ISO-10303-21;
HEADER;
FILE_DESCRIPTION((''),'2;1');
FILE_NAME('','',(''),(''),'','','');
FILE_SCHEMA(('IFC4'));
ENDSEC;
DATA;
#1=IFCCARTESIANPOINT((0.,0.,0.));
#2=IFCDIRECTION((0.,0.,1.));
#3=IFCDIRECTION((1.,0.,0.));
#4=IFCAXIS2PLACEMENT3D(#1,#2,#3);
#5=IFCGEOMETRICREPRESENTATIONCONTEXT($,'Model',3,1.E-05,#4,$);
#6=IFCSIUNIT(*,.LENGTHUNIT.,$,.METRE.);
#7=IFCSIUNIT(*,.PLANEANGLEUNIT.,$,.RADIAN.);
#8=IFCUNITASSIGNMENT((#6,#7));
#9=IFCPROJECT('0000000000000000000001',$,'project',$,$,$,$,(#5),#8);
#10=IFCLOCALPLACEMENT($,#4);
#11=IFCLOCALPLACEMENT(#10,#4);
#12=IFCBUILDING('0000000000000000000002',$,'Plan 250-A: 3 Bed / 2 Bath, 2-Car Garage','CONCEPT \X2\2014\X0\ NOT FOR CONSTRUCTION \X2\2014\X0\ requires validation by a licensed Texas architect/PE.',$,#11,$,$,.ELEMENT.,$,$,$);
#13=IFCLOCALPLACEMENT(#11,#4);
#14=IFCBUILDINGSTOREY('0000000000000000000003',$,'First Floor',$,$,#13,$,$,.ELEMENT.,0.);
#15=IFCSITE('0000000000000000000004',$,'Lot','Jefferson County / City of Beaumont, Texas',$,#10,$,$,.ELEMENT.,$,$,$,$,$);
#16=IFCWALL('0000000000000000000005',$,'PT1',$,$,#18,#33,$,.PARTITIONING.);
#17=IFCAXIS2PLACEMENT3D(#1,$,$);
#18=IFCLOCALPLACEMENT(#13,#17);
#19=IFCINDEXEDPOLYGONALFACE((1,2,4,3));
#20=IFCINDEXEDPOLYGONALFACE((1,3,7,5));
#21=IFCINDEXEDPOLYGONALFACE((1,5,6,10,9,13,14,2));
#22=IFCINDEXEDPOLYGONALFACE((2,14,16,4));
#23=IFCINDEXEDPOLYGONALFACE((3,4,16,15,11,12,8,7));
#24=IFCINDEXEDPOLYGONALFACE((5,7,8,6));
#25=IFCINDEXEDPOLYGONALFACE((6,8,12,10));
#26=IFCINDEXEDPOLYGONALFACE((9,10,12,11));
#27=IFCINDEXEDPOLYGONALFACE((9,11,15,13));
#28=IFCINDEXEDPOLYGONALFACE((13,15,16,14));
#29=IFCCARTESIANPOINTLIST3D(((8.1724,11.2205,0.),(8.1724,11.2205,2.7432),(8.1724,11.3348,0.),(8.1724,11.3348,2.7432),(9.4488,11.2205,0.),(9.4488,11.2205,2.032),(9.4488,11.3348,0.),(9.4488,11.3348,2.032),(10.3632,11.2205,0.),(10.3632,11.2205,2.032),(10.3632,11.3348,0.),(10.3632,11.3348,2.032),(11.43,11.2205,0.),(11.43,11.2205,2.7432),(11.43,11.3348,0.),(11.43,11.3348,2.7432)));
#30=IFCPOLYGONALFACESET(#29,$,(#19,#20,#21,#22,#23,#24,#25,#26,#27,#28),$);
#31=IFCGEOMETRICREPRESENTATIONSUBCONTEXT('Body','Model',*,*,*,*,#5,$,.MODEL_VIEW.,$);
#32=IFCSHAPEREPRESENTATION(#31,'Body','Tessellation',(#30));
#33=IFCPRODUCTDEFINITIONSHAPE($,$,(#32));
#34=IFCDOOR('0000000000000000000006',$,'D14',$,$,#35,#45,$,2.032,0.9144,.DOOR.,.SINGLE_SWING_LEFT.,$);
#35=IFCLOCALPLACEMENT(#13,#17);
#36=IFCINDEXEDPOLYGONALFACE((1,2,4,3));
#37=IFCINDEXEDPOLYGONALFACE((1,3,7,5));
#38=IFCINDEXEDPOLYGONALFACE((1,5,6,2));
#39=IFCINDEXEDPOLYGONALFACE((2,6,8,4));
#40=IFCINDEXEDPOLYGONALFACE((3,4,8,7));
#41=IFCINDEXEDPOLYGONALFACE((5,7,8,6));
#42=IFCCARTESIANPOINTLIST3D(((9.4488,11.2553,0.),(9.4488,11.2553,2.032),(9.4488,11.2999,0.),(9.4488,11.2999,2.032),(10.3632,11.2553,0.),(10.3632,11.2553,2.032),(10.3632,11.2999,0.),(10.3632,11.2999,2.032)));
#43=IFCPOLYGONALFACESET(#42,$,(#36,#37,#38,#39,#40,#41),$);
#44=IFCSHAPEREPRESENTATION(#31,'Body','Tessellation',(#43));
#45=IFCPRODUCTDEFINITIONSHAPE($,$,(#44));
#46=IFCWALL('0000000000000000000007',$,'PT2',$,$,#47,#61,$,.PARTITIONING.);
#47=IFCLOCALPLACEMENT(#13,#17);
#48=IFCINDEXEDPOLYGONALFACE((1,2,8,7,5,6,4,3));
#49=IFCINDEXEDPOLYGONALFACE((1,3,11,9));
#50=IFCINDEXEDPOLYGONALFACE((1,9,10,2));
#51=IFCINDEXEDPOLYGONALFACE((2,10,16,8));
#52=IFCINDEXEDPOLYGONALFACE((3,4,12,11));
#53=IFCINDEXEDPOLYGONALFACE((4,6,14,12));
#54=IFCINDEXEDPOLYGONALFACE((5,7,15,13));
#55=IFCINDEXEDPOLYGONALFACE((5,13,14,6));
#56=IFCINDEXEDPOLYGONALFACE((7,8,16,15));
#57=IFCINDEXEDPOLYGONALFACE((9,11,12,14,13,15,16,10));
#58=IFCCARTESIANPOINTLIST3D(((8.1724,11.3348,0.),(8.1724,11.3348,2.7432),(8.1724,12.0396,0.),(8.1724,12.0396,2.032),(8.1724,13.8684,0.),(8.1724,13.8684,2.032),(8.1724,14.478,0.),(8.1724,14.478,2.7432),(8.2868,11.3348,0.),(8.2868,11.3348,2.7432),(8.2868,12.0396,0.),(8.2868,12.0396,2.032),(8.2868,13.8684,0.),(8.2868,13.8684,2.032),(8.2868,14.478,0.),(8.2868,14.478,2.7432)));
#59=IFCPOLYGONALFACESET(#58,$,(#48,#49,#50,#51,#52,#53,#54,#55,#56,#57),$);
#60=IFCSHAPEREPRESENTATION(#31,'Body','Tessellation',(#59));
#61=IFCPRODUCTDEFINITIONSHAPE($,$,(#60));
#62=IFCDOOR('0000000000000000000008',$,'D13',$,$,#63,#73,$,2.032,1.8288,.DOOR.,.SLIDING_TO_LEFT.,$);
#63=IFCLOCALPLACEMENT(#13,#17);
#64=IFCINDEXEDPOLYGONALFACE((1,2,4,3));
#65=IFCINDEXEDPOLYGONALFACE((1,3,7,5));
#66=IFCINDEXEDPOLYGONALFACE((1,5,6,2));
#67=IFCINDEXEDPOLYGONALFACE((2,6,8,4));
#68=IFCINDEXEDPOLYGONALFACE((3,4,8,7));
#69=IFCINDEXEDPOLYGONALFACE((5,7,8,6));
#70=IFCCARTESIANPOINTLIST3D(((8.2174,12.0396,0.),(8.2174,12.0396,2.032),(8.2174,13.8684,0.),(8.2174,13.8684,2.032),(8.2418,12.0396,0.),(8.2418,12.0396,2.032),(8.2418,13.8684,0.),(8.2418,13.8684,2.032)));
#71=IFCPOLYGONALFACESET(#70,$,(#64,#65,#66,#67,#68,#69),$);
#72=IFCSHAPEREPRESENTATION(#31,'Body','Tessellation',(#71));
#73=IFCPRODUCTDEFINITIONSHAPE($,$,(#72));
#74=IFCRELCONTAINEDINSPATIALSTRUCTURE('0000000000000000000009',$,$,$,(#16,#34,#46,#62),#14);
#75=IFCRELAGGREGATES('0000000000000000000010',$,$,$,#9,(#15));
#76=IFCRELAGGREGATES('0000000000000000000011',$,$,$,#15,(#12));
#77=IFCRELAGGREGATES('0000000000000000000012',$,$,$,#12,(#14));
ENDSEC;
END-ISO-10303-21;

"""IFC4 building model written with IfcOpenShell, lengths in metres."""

from ifc_helpers import new_model, si_unit, frame, frame_2d, origin_with_axes, place, context, subcontext, project, spatial, rectangle, extrude, element, fill, save


model = new_model("IFC4")

# Units and contexts
model_context = context("Model", 3, precision=1e-05, world=origin_with_axes())
body_context = subcontext(model_context, "Body", "Model", "MODEL_VIEW")
ifc_project = project(units=[si_unit("LENGTHUNIT", "METRE"), si_unit("PLANEANGLEUNIT", "RADIAN")], contexts=[model_context])

# Site, building, storey
site_placement = place(None, origin_with_axes())
site = spatial("IfcSite", under=ifc_project, at=site_placement, Name="Lot", Description="Jefferson County / City of Beaumont, Texas", CompositionType="ELEMENT")
building_placement = place(site_placement, origin_with_axes())
building = spatial("IfcBuilding", under=site, at=building_placement, Name="Plan 250-A: 3 Bed / 2 Bath, 2-Car Garage", Description="CONCEPT — NOT FOR CONSTRUCTION — requires validation by a licensed Texas architect/PE.", CompositionType="ELEMENT")
storey_placement = place(building_placement, origin_with_axes())
storey = spatial("IfcBuildingStorey", under=building, at=storey_placement, Name="First Floor", CompositionType="ELEMENT", Elevation=0.0)

# Walls, openings, doors
wall_1_placement = place(storey_placement, frame((8.1724, 11.2776, 0.0), z_axis=(0.0, 0.0, 1.0), x_axis=(1.0, 0.0, 0.0)))
wall_1 = element("IfcWall", 1, at=wall_1_placement, inside=storey, Name="PT1", PredefinedType="PARTITIONING", context=body_context, shape_type="SweptSolid", body=[
    extrude(rectangle(XDim=3.2576, YDim=0.1143, at=frame_2d((1.6288, 0.0), x_axis=(1.0, 0.0))), origin_with_axes(), (0.0, 0.0, 1.0), 2.7432),
])
opening_1_placement = place(wall_1_placement, frame((1.2764, 0.0, 0.0), z_axis=(0.0, 0.0, 1.0), x_axis=(1.0, 0.0, 0.0)))
opening_1 = element("IfcOpeningElement", 2, at=opening_1_placement, cuts=wall_1, PredefinedType="OPENING", context=body_context, shape_type="SweptSolid", body=[
    extrude(rectangle(XDim=0.9144, YDim=0.1448, at=frame_2d((0.4572, 0.0), x_axis=(1.0, 0.0))), origin_with_axes(), (0.0, 0.0, 1.0), 2.032),
])
door_1_placement = place(opening_1_placement, origin_with_axes())
door_1 = element("IfcDoor", 3, at=door_1_placement, inside=storey, Name="D14", OperationType="SINGLE_SWING_LEFT", OverallHeight=2.032, OverallWidth=0.9144, PredefinedType="DOOR", context=body_context, shape_type="SweptSolid", body=[
    extrude(rectangle(XDim=0.9144, YDim=0.0445, at=frame_2d((0.4572, 0.0), x_axis=(1.0, 0.0))), origin_with_axes(), (0.0, 0.0, 1.0), 2.032),
])
fill(opening_1, door_1)
wall_2_placement = place(storey_placement, frame((8.2296, 11.3348, 0.0), z_axis=(0.0, 0.0, 1.0), x_axis=(0.0, 1.0, 0.0)))
wall_2 = element("IfcWall", 4, at=wall_2_placement, inside=storey, Name="PT2", PredefinedType="PARTITIONING", context=body_context, shape_type="SweptSolid", body=[
    extrude(rectangle(XDim=3.1433, YDim=0.1143, at=frame_2d((1.5716, 0.0), x_axis=(1.0, 0.0))), origin_with_axes(), (0.0, 0.0, 1.0), 2.7432),
])
opening_2_placement = place(wall_2_placement, frame((0.7049, 0.0, 0.0), z_axis=(0.0, 0.0, 1.0), x_axis=(1.0, 0.0, 0.0)))
opening_2 = element("IfcOpeningElement", 5, at=opening_2_placement, cuts=wall_2, PredefinedType="OPENING", context=body_context, shape_type="SweptSolid", body=[
    extrude(rectangle(XDim=1.8288, YDim=0.1448, at=frame_2d((0.9144, 0.0), x_axis=(1.0, 0.0))), origin_with_axes(), (0.0, 0.0, 1.0), 2.032),
])
door_2_placement = place(opening_2_placement, origin_with_axes())
door_2 = element("IfcDoor", 6, at=door_2_placement, inside=storey, Name="D13", OperationType="SLIDING_TO_LEFT", OverallHeight=2.032, OverallWidth=1.8288, PredefinedType="DOOR", context=body_context, shape_type="SweptSolid", body=[
    extrude(rectangle(XDim=1.8288, YDim=0.0244, at=frame_2d((0.9144, 0.0), x_axis=(1.0, 0.0))), origin_with_axes(), (0.0, 0.0, 1.0), 2.032),
])
fill(opening_2, door_2)

save(model, "model.ifc")
